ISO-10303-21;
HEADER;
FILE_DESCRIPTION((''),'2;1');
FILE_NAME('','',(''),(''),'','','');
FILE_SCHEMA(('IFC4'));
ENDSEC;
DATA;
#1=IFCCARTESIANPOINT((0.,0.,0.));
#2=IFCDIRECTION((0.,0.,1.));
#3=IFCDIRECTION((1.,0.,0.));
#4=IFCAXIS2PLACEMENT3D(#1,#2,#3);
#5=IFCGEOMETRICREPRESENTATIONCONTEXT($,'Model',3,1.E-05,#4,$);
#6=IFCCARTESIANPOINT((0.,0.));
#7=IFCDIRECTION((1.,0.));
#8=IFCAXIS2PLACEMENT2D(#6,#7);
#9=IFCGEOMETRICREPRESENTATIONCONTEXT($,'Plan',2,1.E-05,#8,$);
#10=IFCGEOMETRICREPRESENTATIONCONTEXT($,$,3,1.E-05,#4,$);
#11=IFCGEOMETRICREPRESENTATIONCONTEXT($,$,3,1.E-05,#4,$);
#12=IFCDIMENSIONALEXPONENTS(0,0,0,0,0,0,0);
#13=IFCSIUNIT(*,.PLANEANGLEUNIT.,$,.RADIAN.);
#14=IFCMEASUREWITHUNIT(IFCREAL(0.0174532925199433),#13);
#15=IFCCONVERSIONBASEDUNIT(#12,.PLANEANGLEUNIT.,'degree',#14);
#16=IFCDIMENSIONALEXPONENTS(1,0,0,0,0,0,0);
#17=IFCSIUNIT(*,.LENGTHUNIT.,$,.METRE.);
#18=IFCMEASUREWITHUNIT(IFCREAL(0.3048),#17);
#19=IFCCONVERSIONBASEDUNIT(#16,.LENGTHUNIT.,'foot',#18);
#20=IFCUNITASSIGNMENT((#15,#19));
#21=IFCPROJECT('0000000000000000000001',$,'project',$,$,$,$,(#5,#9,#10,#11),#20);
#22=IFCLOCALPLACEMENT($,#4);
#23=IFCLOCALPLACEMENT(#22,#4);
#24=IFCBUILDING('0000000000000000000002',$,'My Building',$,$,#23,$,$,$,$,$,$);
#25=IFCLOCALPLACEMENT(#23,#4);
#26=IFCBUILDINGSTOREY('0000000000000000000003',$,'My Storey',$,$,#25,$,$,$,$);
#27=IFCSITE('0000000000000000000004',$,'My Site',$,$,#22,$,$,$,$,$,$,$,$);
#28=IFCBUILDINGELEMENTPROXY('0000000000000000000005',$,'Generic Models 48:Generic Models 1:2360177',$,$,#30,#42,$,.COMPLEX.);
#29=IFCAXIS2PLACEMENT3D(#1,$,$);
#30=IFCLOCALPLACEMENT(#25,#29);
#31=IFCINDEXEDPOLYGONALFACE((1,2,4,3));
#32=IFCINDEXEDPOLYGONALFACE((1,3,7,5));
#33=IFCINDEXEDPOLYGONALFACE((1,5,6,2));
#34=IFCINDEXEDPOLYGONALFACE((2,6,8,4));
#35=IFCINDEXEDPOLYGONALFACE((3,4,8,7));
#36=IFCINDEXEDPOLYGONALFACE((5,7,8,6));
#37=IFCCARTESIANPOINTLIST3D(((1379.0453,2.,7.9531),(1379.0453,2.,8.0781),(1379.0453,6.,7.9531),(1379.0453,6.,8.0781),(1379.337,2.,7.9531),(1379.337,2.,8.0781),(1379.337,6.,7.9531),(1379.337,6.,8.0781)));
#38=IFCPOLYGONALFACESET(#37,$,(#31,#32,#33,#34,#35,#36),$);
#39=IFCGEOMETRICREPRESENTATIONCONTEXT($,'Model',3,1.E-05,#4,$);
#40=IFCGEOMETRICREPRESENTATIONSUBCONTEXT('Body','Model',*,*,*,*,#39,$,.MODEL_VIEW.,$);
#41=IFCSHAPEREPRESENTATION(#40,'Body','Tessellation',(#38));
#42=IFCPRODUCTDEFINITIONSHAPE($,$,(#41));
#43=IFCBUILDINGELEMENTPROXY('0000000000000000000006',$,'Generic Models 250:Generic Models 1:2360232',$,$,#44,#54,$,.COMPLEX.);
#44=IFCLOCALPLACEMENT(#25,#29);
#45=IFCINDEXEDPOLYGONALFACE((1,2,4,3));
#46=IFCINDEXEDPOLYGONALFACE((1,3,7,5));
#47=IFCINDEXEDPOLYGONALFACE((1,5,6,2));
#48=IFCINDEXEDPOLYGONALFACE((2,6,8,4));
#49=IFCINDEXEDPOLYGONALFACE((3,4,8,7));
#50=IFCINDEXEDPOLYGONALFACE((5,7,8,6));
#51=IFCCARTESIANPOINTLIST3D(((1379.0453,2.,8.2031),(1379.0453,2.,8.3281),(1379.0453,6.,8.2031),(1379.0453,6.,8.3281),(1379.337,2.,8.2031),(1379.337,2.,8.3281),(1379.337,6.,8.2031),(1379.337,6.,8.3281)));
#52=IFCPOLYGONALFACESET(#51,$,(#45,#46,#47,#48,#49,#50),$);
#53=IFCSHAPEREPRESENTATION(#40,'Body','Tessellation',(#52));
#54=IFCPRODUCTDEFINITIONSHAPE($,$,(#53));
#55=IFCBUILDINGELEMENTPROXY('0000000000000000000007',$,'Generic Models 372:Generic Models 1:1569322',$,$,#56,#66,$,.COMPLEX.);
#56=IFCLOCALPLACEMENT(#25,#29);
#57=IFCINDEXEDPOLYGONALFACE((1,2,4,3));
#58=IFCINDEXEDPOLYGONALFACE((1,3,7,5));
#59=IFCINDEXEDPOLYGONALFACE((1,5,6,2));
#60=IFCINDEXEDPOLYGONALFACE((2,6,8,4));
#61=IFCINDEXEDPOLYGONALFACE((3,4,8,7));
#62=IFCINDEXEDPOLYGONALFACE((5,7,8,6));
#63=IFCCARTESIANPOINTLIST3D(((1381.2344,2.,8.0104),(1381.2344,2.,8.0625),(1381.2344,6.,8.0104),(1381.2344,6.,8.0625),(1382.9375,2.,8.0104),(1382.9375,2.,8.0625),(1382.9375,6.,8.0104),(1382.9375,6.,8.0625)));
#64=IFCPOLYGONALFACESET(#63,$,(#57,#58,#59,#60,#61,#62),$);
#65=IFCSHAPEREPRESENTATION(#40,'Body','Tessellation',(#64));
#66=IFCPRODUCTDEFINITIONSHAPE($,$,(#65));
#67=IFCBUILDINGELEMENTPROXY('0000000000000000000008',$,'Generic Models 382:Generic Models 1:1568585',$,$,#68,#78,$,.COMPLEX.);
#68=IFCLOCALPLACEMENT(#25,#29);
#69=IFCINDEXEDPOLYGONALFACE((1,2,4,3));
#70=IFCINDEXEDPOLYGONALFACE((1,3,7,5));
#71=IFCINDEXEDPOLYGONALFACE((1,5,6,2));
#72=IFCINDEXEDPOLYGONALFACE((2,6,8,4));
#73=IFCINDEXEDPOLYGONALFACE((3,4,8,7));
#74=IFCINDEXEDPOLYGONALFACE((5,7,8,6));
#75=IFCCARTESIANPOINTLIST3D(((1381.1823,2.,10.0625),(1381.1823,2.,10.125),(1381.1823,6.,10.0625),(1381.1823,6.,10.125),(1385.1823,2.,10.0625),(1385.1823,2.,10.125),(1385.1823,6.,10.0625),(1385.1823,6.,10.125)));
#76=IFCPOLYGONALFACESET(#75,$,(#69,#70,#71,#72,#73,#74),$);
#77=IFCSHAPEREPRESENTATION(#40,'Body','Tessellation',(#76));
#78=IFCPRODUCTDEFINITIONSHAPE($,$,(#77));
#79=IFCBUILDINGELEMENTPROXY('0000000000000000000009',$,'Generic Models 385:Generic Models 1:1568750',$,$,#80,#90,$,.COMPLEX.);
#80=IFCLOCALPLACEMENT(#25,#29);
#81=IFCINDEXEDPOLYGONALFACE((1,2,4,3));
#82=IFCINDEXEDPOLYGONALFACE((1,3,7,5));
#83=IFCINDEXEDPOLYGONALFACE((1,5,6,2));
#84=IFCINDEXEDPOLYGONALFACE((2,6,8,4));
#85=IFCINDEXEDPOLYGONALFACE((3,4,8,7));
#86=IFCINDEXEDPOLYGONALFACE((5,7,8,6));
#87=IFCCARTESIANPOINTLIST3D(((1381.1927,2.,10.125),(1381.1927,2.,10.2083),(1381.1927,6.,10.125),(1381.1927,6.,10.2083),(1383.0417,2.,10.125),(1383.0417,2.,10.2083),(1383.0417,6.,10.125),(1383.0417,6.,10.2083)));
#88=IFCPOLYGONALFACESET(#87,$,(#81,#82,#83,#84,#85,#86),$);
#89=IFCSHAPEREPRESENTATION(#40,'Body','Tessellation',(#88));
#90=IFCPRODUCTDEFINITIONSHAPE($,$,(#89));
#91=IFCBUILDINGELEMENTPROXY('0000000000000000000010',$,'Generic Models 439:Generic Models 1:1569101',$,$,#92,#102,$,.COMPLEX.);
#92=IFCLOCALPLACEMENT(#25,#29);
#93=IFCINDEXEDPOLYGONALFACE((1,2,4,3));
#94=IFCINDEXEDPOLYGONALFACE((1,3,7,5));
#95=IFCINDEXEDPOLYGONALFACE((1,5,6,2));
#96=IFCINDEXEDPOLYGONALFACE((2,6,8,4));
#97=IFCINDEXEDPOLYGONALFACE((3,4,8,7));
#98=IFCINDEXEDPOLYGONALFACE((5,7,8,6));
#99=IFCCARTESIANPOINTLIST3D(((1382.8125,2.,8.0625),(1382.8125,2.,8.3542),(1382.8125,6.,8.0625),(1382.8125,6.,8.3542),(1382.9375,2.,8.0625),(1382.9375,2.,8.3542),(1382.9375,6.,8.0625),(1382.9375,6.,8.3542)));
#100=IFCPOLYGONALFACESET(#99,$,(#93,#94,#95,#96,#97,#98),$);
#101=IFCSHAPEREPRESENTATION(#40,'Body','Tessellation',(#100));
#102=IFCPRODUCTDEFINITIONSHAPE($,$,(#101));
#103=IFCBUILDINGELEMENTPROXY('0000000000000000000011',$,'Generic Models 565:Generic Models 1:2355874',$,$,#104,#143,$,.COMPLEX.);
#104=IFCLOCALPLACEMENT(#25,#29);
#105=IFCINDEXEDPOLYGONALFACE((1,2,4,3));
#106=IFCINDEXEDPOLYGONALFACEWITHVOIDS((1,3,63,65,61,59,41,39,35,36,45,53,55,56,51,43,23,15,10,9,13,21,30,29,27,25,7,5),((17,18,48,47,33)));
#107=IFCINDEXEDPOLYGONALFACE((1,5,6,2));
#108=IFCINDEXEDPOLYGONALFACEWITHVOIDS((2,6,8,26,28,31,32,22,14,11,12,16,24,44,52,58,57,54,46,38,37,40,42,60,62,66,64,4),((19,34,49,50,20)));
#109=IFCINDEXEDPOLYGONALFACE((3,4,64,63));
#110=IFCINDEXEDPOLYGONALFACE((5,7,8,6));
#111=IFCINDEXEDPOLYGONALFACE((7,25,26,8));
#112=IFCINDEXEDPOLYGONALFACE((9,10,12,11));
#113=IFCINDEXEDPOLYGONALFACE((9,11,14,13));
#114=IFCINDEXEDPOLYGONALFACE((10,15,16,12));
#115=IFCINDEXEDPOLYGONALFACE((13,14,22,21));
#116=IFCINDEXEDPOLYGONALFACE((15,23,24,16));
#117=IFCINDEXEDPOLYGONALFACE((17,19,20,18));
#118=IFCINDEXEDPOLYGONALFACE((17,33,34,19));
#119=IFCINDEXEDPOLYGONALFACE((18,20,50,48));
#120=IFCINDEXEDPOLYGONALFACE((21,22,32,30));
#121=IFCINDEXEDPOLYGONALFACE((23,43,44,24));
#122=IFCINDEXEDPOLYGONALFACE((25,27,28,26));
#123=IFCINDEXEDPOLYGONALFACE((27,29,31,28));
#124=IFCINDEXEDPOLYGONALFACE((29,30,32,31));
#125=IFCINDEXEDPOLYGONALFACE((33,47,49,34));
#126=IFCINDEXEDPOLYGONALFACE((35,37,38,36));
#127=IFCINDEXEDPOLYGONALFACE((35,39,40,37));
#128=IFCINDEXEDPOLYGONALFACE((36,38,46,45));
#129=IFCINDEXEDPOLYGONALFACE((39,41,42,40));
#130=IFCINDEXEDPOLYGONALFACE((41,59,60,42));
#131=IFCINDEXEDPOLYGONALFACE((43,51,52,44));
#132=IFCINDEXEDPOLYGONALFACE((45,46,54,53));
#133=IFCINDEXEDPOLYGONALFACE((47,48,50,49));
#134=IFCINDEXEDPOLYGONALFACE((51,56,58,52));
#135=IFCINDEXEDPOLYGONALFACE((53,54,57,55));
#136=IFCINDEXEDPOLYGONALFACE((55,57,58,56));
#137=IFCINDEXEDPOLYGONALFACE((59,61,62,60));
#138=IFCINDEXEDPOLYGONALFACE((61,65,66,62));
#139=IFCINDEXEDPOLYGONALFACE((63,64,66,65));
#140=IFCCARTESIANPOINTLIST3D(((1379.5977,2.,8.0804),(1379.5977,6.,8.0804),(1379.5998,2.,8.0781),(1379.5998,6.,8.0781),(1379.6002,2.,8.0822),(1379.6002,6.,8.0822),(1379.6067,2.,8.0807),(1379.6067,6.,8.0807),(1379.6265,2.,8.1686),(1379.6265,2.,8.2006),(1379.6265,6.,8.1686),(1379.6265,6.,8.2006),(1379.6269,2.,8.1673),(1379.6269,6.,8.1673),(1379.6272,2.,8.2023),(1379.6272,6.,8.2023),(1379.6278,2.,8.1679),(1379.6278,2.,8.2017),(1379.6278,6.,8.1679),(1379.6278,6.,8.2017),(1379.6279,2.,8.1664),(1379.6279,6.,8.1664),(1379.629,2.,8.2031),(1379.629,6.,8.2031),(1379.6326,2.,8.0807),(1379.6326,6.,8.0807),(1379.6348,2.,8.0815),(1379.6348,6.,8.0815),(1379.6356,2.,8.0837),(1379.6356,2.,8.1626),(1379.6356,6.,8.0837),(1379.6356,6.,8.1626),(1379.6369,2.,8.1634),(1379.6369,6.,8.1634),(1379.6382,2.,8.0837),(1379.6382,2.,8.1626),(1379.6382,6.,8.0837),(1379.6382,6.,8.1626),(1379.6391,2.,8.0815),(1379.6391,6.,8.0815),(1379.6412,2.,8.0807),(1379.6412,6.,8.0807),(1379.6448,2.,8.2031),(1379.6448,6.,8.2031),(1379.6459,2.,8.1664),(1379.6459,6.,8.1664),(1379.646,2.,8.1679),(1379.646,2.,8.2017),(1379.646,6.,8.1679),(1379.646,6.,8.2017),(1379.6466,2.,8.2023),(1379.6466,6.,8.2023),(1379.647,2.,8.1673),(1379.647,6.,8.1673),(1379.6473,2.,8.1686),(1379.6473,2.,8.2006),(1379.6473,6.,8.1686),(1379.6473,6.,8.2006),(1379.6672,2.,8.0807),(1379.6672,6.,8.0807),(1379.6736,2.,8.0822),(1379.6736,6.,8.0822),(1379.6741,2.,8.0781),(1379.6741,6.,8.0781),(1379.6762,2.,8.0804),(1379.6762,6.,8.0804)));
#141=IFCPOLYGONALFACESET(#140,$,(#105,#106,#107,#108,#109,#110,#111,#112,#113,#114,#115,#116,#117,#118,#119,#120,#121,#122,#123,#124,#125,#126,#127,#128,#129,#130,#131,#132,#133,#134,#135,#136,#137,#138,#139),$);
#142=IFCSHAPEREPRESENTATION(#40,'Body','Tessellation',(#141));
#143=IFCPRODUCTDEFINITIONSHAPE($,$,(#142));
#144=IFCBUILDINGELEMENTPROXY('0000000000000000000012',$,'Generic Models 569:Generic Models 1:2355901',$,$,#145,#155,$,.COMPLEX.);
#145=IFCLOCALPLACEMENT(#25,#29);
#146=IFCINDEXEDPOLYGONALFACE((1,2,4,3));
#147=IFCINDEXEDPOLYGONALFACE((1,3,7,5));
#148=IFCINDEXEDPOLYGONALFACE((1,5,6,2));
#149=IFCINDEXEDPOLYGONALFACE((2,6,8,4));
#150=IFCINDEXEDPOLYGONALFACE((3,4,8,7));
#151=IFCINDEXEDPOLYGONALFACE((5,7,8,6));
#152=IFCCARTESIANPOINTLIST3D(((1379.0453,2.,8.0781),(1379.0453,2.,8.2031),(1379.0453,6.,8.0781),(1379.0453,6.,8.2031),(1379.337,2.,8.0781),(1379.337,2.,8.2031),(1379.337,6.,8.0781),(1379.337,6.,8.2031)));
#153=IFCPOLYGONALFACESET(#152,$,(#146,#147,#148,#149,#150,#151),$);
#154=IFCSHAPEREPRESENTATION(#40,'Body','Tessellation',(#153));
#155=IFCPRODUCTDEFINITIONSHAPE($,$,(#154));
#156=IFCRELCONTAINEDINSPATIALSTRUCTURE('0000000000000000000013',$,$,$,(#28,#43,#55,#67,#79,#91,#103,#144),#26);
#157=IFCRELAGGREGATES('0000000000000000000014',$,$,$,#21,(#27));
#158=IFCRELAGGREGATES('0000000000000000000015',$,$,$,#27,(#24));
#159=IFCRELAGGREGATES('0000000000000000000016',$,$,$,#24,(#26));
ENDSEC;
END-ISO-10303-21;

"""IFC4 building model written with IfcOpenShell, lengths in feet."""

from ifc_helpers import new_model, entity, si_unit, converted_unit, frame, origin_with_axes, origin_2d_with_axis, place, context, subcontext, project, spatial, polyline, line, indexed_curve, outline, extrude, element, save


model = new_model("IFC4")

# Units and contexts
model_context_1 = context("Model", 3, precision=1e-05, world=origin_with_axes())
plan_context = context("Plan", 2, precision=1e-05, world=origin_2d_with_axis())
model_context_2 = context("Model", 3, precision=1e-05, world=origin_with_axes())
context_of_model_1 = context(None, 3, precision=1e-05, world=origin_with_axes())
context_of_model_2 = context(None, 3, precision=1e-05, world=origin_with_axes())
body_context = subcontext(model_context_2, "Body", "Model", "MODEL_VIEW")
ifc_project = project(units=[converted_unit("PLANEANGLEUNIT", "degree", entity("IfcReal", 0.0174532925199433), si_unit("PLANEANGLEUNIT", "RADIAN"), dimensions=[0, 0, 0, 0, 0, 0, 0]), converted_unit("LENGTHUNIT", "foot", entity("IfcReal", 0.3048), si_unit("LENGTHUNIT", "METRE"), dimensions=[1, 0, 0, 0, 0, 0, 0])], contexts=[model_context_1, plan_context, context_of_model_1, context_of_model_2])

# Site, building, storey
site_placement = place(None, origin_with_axes())
site = spatial("IfcSite", under=ifc_project, at=site_placement, Name="My Site")
building_placement = place(site_placement, origin_with_axes())
building = spatial("IfcBuilding", under=site, at=building_placement, Name="My Building")
storey_placement = place(building_placement, origin_with_axes())
storey = spatial("IfcBuildingStorey", under=building, at=storey_placement, Name="My Storey")

# Building element proxies
proxy_1_placement = place(storey_placement, frame((1379.0453, 6.0, 7.9531), z_axis=(0.0, -1.0, 0.0), x_axis=(0.0, 0.0, 1.0)))
element("IfcBuildingElementProxy", 1, at=proxy_1_placement, inside=storey, Name="Generic Models 48:Generic Models 1:2360177", PredefinedType="COMPLEX", context=body_context, shape_type="SweptSolid", body=[
    extrude(outline(polyline([(-0.1458, -0.0625), (0.1458, -0.0625), (0.1458, 0.0625), (-0.1458, 0.0625), (-0.1458, -0.0625)])), frame((0.0625, -0.1458, 0.0), z_axis=(0.0, 0.0, -1.0), x_axis=(0.0, 1.0, 0.0)), (0.0, 0.0, -1.0), 4.0),
])
proxy_2_placement = place(storey_placement, frame((1379.0453, 6.0, 8.2031), z_axis=(0.0, -1.0, 0.0), x_axis=(0.0, 0.0, 1.0)))
element("IfcBuildingElementProxy", 2, at=proxy_2_placement, inside=storey, Name="Generic Models 250:Generic Models 1:2360232", PredefinedType="COMPLEX", context=body_context, shape_type="SweptSolid", body=[
    extrude(outline(polyline([(-0.0625, -0.1458), (0.0625, -0.1458), (0.0625, 0.1458), (-0.0625, 0.1458), (-0.0625, -0.1458)])), frame((0.0625, -0.1458, 0.0), z_axis=(0.0, 0.0, -1.0), x_axis=(-1.0, 0.0, 0.0)), (0.0, 0.0, -1.0), 4.0),
])
proxy_3_placement = place(storey_placement, frame((1381.2344, 6.0, 8.0104), z_axis=(0.0, -1.0, 0.0), x_axis=(0.0, 0.0, 1.0)))
element("IfcBuildingElementProxy", 3, at=proxy_3_placement, inside=storey, Name="Generic Models 372:Generic Models 1:1569322", PredefinedType="COMPLEX", context=body_context, shape_type="SweptSolid", body=[
    extrude(outline(polyline([(-0.026, -0.8516), (0.026, -0.8516), (0.026, 0.8516), (-0.026, 0.8516), (-0.026, -0.8516)])), frame((0.026, -0.8516, 0.0), z_axis=(0.0, 0.0, -1.0), x_axis=(1.0, 0.0, 0.0)), (0.0, 0.0, -1.0), 4.0),
])
proxy_4_placement = place(storey_placement, frame((1381.1823, 6.0, 10.0625), z_axis=(0.0, -1.0, 0.0), x_axis=(0.0, 0.0, 1.0)))
element("IfcBuildingElementProxy", 4, at=proxy_4_placement, inside=storey, Name="Generic Models 382:Generic Models 1:1568585", PredefinedType="COMPLEX", context=body_context, shape_type="SweptSolid", body=[
    extrude(outline(polyline([(-0.0313, -2.0), (0.0312, -2.0), (0.0313, 2.0), (-0.0312, 2.0), (-0.0313, -2.0)])), frame((0.0313, -2.0, 0.0), z_axis=(0.0, 0.0, -1.0), x_axis=(-1.0, 0.0, 0.0)), (0.0, 0.0, -1.0), 4.0),
])
proxy_5_placement = place(storey_placement, frame((1381.1927, 6.0, 10.125), z_axis=(0.0, -1.0, 0.0), x_axis=(0.0, 0.0, 1.0)))
element("IfcBuildingElementProxy", 5, at=proxy_5_placement, inside=storey, Name="Generic Models 385:Generic Models 1:1568750", PredefinedType="COMPLEX", context=body_context, shape_type="SweptSolid", body=[
    extrude(outline(polyline([(-0.0417, -0.9245), (0.0417, -0.9245), (0.0417, 0.9245), (-0.0417, 0.9245), (-0.0417, -0.9245)])), frame((0.0417, -0.9245, 0.0), z_axis=(0.0, 0.0, -1.0), x_axis=(1.0, 0.0, 0.0)), (0.0, 0.0, -1.0), 4.0),
])
proxy_6_placement = place(storey_placement, frame((1382.8125, 6.0, 8.0625), z_axis=(0.0, -1.0, 0.0), x_axis=(0.0, 0.0, 1.0)))
element("IfcBuildingElementProxy", 6, at=proxy_6_placement, inside=storey, Name="Generic Models 439:Generic Models 1:1569101", PredefinedType="COMPLEX", context=body_context, shape_type="SweptSolid", body=[
    extrude(outline(polyline([(-0.0625, -0.1458), (0.0625, -0.1458), (0.0625, 0.1458), (-0.0625, 0.1458), (-0.0625, -0.1458)])), frame((0.1458, -0.0625, 0.0), z_axis=(0.0, 0.0, -1.0), x_axis=(0.0, 1.0, 0.0)), (0.0, 0.0, -1.0), 4.0),
])
proxy_7_placement = place(storey_placement, frame((1379.5977, 6.0, 8.0781), z_axis=(0.0, -1.0, 0.0), x_axis=(0.0, 0.0, 1.0)))
element("IfcBuildingElementProxy", 7, at=proxy_7_placement, inside=storey, Name="Generic Models 565:Generic Models 1:2355874", PredefinedType="COMPLEX", context=body_context, shape_type="SweptSolid", body=[
    extrude(outline(indexed_curve([(0.0297, 0.0058), (0.0311, 0.006), (0.0627, 0.0015), (0.0643, 0.0005), (0.0648, -0.0014), (0.0625, -0.017), (0.0615, -0.0187), (0.0597, -0.0192), (0.0281, -0.0146), (0.0268, -0.014), (0.0261, -0.0129), (0.0234, -0.0047), (-0.0547, 0.0066), (-0.0569, 0.006), (-0.0581, 0.0041), (-0.0618, -0.0216), (-0.0612, -0.0282), (-0.0634, -0.0305), (-0.0654, -0.0281), (-0.0547, 0.0455), (-0.0522, 0.0472), (-0.0507, 0.0444), (-0.0532, 0.0382), (-0.0569, 0.0126), (-0.0563, 0.0103), (-0.0543, 0.0092), (0.0238, -0.0021), (0.0286, 0.005), (0.0301, 0.0048), (0.0637, 0.0), (0.0611, -0.018), (0.0275, -0.0132), (0.0244, -0.0035)], segments=[line(7, 6), line(6, 5), line(5, 4), line(4, 3), line(3, 2), line(2, 1), line(1, 28), line(28, 27), line(27, 26), line(26, 25), line(25, 24), line(24, 23), line(23, 22), line(22, 21), line(21, 20), line(20, 19), line(19, 18), line(18, 17), line(17, 16), line(16, 15), line(15, 14), line(14, 13), line(13, 12), line(12, 11), line(11, 10), line(10, 9), line(9, 8), line(8, 7)], self_intersect=False), holes=[indexed_curve([(0.0297, 0.0058), (0.0311, 0.006), (0.0627, 0.0015), (0.0643, 0.0005), (0.0648, -0.0014), (0.0625, -0.017), (0.0615, -0.0187), (0.0597, -0.0192), (0.0281, -0.0146), (0.0268, -0.014), (0.0261, -0.0129), (0.0234, -0.0047), (-0.0547, 0.0066), (-0.0569, 0.006), (-0.0581, 0.0041), (-0.0618, -0.0216), (-0.0612, -0.0282), (-0.0634, -0.0305), (-0.0654, -0.0281), (-0.0547, 0.0455), (-0.0522, 0.0472), (-0.0507, 0.0444), (-0.0532, 0.0382), (-0.0569, 0.0126), (-0.0563, 0.0103), (-0.0543, 0.0092), (0.0238, -0.0021), (0.0286, 0.005), (0.0301, 0.0048), (0.0637, 0.0), (0.0611, -0.018), (0.0275, -0.0132), (0.0244, -0.0035)], segments=[line(31, 32), line(32, 33), line(33, 29), line(29, 30), line(30, 31)], self_intersect=False)]), frame((0.0607, -0.0392, 0.0), z_axis=(0.0, 0.0, -1.0), x_axis=(0.989698, -0.14317, 0.0)), (0.0, 0.0, -1.0), 4.0),
])
proxy_8_placement = place(storey_placement, frame((1379.0453, 6.0, 8.0781), z_axis=(0.0, -1.0, 0.0), x_axis=(0.0, 0.0, 1.0)))
element("IfcBuildingElementProxy", 8, at=proxy_8_placement, inside=storey, Name="Generic Models 569:Generic Models 1:2355901", PredefinedType="COMPLEX", context=body_context, shape_type="SweptSolid", body=[
    extrude(outline(polyline([(-0.1458, -0.0625), (0.1458, -0.0625), (0.1458, 0.0625), (-0.1458, 0.0625), (-0.1458, -0.0625)])), frame((0.0625, -0.1458, 0.0), z_axis=(0.0, 0.0, -1.0), x_axis=(0.0, 1.0, 0.0)), (0.0, 0.0, -1.0), 4.0),
])

save(model, "model.ifc")
